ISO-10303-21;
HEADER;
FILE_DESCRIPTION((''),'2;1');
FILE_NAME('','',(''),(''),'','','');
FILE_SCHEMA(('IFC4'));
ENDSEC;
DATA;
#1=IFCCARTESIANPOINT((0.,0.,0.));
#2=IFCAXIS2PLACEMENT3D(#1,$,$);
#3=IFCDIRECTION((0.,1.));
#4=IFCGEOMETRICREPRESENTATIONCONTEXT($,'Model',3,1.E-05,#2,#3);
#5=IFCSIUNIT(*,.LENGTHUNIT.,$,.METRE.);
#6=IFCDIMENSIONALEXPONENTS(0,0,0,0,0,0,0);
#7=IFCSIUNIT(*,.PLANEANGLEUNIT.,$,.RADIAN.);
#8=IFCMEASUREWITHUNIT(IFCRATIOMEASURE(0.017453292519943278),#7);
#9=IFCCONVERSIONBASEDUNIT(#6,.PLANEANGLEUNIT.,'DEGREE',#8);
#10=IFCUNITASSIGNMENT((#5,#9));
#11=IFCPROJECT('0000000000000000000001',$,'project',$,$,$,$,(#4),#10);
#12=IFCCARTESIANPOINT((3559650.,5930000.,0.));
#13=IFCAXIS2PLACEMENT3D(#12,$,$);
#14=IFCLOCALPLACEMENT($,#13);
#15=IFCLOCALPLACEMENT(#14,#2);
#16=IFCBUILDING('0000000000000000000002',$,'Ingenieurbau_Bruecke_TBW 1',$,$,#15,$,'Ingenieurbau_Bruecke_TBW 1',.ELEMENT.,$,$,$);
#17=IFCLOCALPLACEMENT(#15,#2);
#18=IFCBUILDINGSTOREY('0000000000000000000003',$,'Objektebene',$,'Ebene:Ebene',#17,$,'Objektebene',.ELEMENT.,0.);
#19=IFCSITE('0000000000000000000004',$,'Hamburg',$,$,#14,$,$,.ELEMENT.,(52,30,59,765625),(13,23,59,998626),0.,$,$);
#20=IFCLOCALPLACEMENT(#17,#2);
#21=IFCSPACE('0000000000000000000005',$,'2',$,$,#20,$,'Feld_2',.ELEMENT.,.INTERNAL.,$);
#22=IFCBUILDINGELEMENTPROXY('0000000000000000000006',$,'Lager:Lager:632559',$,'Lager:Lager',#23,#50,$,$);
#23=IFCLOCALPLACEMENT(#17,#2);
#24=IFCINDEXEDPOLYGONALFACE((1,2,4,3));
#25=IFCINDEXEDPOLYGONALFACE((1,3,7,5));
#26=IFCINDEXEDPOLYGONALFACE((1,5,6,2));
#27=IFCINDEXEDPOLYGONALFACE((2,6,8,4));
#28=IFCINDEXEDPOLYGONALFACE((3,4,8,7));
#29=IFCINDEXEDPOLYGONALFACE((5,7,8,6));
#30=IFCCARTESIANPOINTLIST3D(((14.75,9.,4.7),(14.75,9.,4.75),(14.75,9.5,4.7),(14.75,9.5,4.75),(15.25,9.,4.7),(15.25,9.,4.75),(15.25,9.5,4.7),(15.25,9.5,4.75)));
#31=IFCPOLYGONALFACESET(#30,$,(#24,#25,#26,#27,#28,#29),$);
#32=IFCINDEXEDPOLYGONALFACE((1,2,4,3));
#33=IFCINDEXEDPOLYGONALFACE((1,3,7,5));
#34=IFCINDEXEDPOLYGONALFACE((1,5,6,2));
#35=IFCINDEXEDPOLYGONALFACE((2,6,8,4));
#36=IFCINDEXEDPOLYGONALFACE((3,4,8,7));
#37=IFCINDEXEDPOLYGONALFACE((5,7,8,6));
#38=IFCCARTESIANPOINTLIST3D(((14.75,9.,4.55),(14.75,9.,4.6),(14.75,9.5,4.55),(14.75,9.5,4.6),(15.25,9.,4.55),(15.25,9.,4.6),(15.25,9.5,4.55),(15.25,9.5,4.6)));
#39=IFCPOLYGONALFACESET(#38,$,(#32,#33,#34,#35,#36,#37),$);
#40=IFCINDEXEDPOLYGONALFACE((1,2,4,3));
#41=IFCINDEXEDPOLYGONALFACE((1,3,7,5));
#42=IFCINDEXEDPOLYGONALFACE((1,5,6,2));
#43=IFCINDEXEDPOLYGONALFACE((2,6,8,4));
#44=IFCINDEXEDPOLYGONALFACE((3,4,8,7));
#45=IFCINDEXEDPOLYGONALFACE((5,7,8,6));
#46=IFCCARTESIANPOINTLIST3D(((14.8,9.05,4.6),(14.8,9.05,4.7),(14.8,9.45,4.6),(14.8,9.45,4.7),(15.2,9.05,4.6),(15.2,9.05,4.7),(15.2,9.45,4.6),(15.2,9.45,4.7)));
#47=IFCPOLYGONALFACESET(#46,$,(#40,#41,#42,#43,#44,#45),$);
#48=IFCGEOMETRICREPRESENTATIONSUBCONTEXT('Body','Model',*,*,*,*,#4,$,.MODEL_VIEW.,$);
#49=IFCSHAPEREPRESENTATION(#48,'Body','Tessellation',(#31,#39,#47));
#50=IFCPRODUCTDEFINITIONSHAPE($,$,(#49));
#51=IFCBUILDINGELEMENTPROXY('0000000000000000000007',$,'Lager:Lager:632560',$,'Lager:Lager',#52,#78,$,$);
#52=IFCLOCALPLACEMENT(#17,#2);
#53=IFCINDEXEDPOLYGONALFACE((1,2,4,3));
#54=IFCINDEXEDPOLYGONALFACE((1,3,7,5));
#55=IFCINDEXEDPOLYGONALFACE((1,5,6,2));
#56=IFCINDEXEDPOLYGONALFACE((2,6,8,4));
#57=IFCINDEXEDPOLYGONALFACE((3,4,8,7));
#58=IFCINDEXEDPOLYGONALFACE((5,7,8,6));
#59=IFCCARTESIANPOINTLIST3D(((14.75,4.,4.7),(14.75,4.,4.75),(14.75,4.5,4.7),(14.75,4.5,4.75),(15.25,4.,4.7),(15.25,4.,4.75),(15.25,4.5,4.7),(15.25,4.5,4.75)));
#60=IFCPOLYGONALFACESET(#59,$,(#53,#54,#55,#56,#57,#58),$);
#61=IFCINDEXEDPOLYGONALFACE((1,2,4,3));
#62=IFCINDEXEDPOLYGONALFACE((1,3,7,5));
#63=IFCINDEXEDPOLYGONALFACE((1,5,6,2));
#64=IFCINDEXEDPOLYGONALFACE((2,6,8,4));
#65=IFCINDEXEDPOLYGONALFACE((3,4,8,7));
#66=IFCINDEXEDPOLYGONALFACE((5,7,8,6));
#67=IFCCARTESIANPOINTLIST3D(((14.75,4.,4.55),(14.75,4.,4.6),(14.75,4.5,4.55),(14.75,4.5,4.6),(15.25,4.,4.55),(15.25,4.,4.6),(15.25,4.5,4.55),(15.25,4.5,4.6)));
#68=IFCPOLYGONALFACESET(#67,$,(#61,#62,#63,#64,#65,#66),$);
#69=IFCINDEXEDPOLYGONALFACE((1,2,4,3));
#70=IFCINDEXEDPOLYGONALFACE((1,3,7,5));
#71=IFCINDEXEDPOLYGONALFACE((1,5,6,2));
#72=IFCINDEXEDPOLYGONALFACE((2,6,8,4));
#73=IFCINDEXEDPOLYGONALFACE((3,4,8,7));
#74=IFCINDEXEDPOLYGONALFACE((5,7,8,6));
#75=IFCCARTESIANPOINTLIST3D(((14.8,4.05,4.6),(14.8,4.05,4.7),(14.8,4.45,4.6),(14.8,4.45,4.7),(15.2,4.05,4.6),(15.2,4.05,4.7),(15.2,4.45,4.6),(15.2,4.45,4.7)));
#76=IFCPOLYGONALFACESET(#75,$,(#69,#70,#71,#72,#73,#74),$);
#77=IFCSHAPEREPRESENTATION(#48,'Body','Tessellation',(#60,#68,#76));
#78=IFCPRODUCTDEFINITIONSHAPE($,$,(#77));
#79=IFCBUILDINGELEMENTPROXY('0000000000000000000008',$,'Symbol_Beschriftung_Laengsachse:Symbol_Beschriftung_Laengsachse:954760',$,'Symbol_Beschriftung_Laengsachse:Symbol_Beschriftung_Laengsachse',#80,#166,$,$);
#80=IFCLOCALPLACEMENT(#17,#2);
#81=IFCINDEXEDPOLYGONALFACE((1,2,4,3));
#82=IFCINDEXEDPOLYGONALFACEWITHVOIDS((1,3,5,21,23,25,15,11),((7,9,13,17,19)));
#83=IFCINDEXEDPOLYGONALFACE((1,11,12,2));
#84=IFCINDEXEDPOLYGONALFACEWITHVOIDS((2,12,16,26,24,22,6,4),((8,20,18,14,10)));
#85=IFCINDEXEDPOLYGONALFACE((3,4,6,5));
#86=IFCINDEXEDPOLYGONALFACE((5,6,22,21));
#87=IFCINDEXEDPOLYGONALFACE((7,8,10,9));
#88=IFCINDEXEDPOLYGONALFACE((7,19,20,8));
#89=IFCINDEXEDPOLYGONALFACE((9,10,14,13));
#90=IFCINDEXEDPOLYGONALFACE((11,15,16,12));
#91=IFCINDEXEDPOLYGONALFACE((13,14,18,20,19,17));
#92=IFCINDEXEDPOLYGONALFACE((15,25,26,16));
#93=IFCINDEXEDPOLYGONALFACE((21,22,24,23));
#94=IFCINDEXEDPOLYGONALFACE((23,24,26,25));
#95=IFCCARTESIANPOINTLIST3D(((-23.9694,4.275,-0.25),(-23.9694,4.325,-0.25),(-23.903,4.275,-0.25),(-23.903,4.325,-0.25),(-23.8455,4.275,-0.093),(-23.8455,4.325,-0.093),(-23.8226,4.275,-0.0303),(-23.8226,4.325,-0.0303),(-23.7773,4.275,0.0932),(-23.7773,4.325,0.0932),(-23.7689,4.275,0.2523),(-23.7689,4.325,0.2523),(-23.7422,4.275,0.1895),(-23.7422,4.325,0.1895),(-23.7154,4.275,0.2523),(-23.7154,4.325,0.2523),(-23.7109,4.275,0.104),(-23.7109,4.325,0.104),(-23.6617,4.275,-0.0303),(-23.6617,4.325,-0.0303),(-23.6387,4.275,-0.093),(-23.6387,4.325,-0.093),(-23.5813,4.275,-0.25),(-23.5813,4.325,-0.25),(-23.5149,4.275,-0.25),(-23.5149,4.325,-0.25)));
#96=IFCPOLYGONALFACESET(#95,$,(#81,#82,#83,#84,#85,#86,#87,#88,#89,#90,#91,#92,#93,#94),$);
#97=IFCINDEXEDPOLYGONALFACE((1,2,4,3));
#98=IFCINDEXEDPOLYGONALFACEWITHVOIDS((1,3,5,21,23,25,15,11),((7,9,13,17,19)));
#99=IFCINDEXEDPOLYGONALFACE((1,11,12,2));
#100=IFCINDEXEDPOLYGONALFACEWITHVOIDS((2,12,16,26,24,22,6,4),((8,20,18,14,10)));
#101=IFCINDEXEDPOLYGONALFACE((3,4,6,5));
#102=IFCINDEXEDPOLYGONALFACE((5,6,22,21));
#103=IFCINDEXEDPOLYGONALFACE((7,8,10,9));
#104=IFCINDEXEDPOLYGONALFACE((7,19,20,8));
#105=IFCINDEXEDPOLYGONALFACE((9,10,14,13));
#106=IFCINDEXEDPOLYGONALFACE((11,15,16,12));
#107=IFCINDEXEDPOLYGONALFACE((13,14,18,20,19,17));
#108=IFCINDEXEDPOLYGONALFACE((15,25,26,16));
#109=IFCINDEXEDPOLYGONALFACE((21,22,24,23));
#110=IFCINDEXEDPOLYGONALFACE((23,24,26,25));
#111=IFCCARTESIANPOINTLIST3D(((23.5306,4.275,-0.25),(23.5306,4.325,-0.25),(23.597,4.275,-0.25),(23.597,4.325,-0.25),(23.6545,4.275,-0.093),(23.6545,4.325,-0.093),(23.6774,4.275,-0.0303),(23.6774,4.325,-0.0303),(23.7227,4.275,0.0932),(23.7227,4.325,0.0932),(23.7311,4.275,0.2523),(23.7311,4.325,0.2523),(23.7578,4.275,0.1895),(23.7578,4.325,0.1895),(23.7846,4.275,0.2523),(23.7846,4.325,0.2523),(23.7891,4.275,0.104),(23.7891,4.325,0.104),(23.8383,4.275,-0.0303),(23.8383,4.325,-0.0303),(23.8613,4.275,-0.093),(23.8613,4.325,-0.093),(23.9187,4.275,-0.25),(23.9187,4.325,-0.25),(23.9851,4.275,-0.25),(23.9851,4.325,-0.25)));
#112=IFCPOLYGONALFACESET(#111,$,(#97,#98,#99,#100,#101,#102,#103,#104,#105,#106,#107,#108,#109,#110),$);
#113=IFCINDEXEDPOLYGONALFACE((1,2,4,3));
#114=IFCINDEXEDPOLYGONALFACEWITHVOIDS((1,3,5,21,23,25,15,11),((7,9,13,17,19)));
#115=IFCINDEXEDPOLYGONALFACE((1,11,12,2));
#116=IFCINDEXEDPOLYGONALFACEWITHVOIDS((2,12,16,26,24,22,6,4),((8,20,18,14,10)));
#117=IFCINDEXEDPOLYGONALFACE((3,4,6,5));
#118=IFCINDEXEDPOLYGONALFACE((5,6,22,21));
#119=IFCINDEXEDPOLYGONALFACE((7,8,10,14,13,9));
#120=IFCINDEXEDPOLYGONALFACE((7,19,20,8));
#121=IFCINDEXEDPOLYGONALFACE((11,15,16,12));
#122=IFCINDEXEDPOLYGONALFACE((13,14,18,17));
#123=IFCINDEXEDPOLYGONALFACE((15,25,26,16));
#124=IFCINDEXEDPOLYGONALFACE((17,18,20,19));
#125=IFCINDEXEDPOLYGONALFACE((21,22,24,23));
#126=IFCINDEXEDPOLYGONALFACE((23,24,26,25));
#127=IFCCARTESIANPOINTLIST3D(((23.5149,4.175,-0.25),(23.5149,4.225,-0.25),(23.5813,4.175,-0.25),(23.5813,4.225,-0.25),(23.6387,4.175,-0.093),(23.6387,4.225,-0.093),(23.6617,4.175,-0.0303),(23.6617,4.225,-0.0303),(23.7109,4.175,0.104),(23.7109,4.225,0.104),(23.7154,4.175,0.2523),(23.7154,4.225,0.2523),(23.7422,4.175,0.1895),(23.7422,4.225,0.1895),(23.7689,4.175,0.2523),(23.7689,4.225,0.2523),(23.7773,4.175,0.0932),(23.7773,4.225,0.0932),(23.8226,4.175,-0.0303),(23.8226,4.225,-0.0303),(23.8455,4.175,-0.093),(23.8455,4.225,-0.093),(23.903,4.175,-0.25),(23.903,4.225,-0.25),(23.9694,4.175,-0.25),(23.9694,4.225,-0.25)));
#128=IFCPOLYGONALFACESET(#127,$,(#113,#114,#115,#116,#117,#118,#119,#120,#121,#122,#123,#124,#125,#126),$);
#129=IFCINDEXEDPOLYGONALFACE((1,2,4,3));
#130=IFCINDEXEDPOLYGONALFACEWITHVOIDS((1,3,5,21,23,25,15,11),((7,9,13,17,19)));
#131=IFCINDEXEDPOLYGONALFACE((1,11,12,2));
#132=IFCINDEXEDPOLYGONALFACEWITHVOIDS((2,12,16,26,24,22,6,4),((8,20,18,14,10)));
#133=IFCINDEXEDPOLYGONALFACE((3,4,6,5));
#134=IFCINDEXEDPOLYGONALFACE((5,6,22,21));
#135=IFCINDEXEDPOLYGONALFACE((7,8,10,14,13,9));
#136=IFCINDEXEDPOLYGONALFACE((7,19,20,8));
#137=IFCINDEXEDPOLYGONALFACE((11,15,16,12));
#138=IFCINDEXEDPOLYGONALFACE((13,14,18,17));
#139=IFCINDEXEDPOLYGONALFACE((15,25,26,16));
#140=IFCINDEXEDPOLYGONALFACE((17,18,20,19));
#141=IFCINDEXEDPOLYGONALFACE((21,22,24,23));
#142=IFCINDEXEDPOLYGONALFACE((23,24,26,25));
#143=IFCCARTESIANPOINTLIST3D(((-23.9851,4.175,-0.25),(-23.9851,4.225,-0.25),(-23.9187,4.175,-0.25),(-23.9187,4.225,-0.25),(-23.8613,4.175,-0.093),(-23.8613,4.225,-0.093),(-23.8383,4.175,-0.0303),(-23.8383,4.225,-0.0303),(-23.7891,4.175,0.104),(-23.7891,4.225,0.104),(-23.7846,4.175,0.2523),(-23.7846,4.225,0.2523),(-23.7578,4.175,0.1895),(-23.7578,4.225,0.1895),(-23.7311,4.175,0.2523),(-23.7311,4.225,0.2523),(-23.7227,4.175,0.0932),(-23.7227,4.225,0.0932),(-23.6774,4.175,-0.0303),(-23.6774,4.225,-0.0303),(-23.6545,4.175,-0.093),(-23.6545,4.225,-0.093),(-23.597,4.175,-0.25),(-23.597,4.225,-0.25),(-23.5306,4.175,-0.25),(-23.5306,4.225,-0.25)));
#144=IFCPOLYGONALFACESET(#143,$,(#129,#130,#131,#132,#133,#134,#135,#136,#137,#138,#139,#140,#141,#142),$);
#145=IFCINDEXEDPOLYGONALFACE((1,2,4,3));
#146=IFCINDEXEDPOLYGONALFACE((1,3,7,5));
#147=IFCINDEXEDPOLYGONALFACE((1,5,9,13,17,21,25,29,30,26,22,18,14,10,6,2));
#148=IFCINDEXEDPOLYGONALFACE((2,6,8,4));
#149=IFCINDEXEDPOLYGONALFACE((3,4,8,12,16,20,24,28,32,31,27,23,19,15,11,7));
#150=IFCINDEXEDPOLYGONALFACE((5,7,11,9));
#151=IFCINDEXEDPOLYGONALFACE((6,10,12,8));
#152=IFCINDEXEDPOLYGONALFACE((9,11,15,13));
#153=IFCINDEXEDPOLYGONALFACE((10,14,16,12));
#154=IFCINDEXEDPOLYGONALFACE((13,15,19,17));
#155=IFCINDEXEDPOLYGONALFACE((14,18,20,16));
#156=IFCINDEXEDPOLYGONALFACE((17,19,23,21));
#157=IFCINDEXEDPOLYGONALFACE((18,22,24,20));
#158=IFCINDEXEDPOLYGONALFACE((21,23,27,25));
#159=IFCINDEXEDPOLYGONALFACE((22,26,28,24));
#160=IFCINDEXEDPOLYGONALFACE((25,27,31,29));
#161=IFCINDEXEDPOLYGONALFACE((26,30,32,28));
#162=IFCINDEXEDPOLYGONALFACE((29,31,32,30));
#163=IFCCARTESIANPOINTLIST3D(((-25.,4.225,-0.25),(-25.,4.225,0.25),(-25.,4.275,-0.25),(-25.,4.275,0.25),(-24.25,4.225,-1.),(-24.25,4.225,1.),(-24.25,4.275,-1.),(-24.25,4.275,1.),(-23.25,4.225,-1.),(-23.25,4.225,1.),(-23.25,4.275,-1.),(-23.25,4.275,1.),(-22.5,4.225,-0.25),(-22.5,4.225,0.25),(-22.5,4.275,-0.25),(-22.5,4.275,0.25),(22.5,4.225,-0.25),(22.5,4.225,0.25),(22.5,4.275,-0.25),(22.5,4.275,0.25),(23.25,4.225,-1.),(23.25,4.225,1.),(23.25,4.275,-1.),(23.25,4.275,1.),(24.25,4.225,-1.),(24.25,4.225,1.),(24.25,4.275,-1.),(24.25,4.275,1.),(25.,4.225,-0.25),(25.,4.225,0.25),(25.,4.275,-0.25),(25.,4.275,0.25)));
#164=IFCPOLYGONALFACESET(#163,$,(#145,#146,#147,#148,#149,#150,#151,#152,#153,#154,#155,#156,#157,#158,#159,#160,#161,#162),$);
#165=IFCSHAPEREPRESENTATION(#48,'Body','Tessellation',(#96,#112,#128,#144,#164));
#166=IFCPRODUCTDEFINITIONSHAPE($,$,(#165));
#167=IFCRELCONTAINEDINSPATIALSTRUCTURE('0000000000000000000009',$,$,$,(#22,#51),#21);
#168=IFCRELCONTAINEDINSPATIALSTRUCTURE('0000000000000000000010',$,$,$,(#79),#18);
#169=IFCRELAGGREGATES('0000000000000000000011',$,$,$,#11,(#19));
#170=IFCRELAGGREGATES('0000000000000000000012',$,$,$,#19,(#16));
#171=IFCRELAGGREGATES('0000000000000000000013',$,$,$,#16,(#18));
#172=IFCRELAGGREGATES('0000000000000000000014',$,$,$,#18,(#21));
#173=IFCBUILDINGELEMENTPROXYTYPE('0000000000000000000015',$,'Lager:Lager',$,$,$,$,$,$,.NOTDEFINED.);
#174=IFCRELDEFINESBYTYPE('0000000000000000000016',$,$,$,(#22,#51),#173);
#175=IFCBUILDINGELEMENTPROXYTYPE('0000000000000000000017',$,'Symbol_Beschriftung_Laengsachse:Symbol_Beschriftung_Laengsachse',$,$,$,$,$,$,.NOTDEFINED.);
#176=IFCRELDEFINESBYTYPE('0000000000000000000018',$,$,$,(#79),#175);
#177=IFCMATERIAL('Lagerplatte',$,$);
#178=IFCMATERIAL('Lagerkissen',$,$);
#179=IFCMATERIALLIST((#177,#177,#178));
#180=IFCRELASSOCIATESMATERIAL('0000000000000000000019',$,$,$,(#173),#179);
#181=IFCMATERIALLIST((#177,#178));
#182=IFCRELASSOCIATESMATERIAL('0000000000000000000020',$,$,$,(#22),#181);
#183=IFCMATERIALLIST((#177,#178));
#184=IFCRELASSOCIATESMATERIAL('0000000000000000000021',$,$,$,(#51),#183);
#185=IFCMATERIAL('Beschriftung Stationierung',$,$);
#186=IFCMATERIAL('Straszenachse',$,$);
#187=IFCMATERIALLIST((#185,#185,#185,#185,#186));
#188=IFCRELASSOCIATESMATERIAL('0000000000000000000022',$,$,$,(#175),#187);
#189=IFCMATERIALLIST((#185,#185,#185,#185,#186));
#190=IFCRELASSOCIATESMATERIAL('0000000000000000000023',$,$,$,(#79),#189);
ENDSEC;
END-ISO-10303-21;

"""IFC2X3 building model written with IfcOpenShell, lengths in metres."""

from ifc_helpers import new_model, entity, si_unit, converted_unit, direction, frame, origin, origin_2d_with_axis, place, context, subcontext, project, spatial, polyline, rectangle, outline, extrude, source, transform, mapped, material, material_list, type_object, type_shapes, element, save


model = new_model("IFC2X3")

# Units and contexts
model_context = context("Model", 3, precision=1e-05, world=origin(), true_north=direction((0.0, 1.0)))
body_context = subcontext(model_context, "Body", "Model", "MODEL_VIEW")
ifc_project = project(units=[si_unit("LENGTHUNIT", "METRE"), converted_unit("PLANEANGLEUNIT", "DEGREE", entity("IfcRatioMeasure", 0.017453292519943278), si_unit("PLANEANGLEUNIT", "RADIAN"), dimensions=[0, 0, 0, 0, 0, 0, 0])], contexts=[model_context])

# Site, building, storey
site_placement = place(None, frame((3559650.0, 5930000.0, 0.0)))
site = spatial("IfcSite", under=ifc_project, at=site_placement, Name="Hamburg", CompositionType="ELEMENT", RefLatitude=(52, 30, 59, 765625), RefLongitude=(13, 23, 59, 998626), RefElevation=0.0)
building_placement = place(site_placement, origin())
building = spatial("IfcBuilding", under=site, at=building_placement, Name="Ingenieurbau_Bruecke_TBW 1", LongName="Ingenieurbau_Bruecke_TBW 1", CompositionType="ELEMENT")
storey_placement = place(building_placement, origin())
storey = spatial("IfcBuildingStorey", under=building, at=storey_placement, Name="Objektebene", ObjectType="Ebene:Ebene", LongName="Objektebene", CompositionType="ELEMENT", Elevation=0.0)

# Shared definitions
space_1_placement = place(storey_placement, origin())
space_1 = spatial("IfcSpace", under=storey, at=space_1_placement, Name="2", LongName="Feld_2", CompositionType="ELEMENT", InteriorOrExteriorSpace="INTERNAL")

# Building element proxies
ifc_material_1 = material(Name="Lagerplatte")
ifc_material_2 = material(Name="Lagerkissen")
ifc_material_list_1 = material_list([ifc_material_1, ifc_material_2])
ifc_material_list_2 = material_list([ifc_material_1, ifc_material_1, ifc_material_2])
building_element_proxy_type_1 = type_object("IfcBuildingElementProxyType", Name="Lager:Lager", PredefinedType="NOTDEFINED", material=ifc_material_list_2)
shared_shape_1 = source(origin(), body_context, "Body", "SweptSolid", [
    extrude(rectangle(XDim=0.5, YDim=0.5, at=origin_2d_with_axis()), frame((0.0, 0.0, 4.7), z_axis=(0.0, 0.0, 1.0), x_axis=(0.0, 1.0, 0.0)), (0.0, 0.0, 1.0), 0.05),
    extrude(rectangle(XDim=0.5, YDim=0.5, at=origin_2d_with_axis()), frame((0.0, 0.0, 4.55), z_axis=(0.0, 0.0, 1.0), x_axis=(0.0, 1.0, 0.0)), (0.0, 0.0, 1.0), 0.05),
    extrude(rectangle(XDim=0.4, YDim=0.4, at=origin_2d_with_axis()), frame((0.0, 0.0, 4.6), z_axis=(0.0, 0.0, 1.0), x_axis=(0.0, 1.0, 0.0)), (0.0, 0.0, 1.0), 0.1),
])
type_shapes(building_element_proxy_type_1, [shared_shape_1])
proxy_1_placement = place(space_1_placement, frame((15.0, 9.25, 0.0)))
element("IfcBuildingElementProxy", 1, at=proxy_1_placement, inside=space_1, type_object=building_element_proxy_type_1, material=ifc_material_list_1, Name="Lager:Lager:632559", ObjectType="Lager:Lager", context=body_context, shape_type="MappedRepresentation", body=[
    mapped(shared_shape_1, transform((0.0, 0.0, 0.0), scale=1.0)),
])
ifc_material_list_3 = material_list([ifc_material_1, ifc_material_2])
proxy_2_placement = place(space_1_placement, frame((15.0, 4.25, 0.0)))
element("IfcBuildingElementProxy", 2, at=proxy_2_placement, inside=space_1, type_object=building_element_proxy_type_1, material=ifc_material_list_3, Name="Lager:Lager:632560", ObjectType="Lager:Lager", context=body_context, shape_type="MappedRepresentation", body=[
    mapped(shared_shape_1, transform((0.0, 0.0, 0.0), scale=1.0)),
])
ifc_material_3 = material(Name="Beschriftung Stationierung")
ifc_material_4 = material(Name="Straszenachse")
ifc_material_list_4 = material_list([ifc_material_3, ifc_material_3, ifc_material_3, ifc_material_3, ifc_material_4])
ifc_material_list_5 = material_list([ifc_material_3, ifc_material_3, ifc_material_3, ifc_material_3, ifc_material_4])
building_element_proxy_type_2 = type_object("IfcBuildingElementProxyType", Name="Symbol_Beschriftung_Laengsachse:Symbol_Beschriftung_Laengsachse", PredefinedType="NOTDEFINED", material=ifc_material_list_5)
shared_shape_2 = source(origin(), body_context, "Body", "SweptSolid", [
    extrude(outline(polyline([(-0.2272, -0.1648), (-0.1609, -0.1648), (-0.1035, -0.0078), (0.1034, -0.0078), (0.1609, -0.1648), (0.2272, -0.1648), (0.0267, 0.3375), (-0.0267, 0.3375), (-0.2272, -0.1648)]), holes=[polyline([(-0.0804, 0.0549), (-0.0313, 0.1892), (0.0, 0.2747), (0.0352, 0.1784), (0.0805, 0.0549), (-0.0804, 0.0549)])]), frame((-23.7421, 0.025, -0.0852), z_axis=(0.0, 1.0, 0.0), x_axis=(-1.0, 0.0, 0.0)), (0.0, 0.0, 1.0), 0.05),
    extrude(outline(polyline([(-0.2272, -0.1648), (-0.1609, -0.1648), (-0.1035, -0.0078), (0.1034, -0.0078), (0.1609, -0.1648), (0.2272, -0.1648), (0.0267, 0.3375), (-0.0267, 0.3375), (-0.2272, -0.1648)]), holes=[polyline([(-0.0804, 0.0549), (-0.0313, 0.1892), (0.0, 0.2747), (0.0352, 0.1784), (0.0805, 0.0549), (-0.0804, 0.0549)])]), frame((23.7579, 0.025, -0.0852), z_axis=(0.0, 1.0, 0.0), x_axis=(-1.0, 0.0, 0.0)), (0.0, 0.0, 1.0), 0.05),
    extrude(outline(polyline([(-0.2373, -0.1499), (0.3035, -0.1499), (0.3233, -0.1003), (-0.0688, 0.2722), (-0.0934, 0.2105), (0.031, 0.0989), (-0.0457, -0.0932), (-0.2127, -0.0883), (-0.2373, -0.1499)]), holes=[polyline([(0.0212, -0.0951), (0.0809, 0.0544), (0.1788, -0.0334), (0.2551, -0.1018), (0.1641, -0.0992), (0.0212, -0.0951)])]), frame((23.7421, -0.075, -0.0852), z_axis=(0.0, 1.0, 0.0), x_axis=(0.370726, 0.0, 0.928742)), (0.0, 0.0, 1.0), 0.05),
    extrude(outline(polyline([(-0.2373, -0.1499), (0.3035, -0.1499), (0.3233, -0.1003), (-0.0688, 0.2722), (-0.0934, 0.2105), (0.031, 0.0989), (-0.0457, -0.0932), (-0.2127, -0.0883), (-0.2373, -0.1499)]), holes=[polyline([(0.0212, -0.0951), (0.0809, 0.0544), (0.1788, -0.0334), (0.2551, -0.1018), (0.1641, -0.0992), (0.0212, -0.0951)])]), frame((-23.7579, -0.075, -0.0852), z_axis=(0.0, 1.0, 0.0), x_axis=(0.370726, 0.0, 0.928742)), (0.0, 0.0, 1.0), 0.05),
    extrude(outline(polyline([(-17.5009, -17.8544), (-16.4402, -17.8544), (-15.7331, -17.1473), (-15.7331, -16.0867), (16.0867, 15.7331), (17.1473, 15.7331), (17.8544, 16.4402), (17.8544, 17.5009), (17.5009, 17.8544), (16.4402, 17.8544), (15.7331, 17.1473), (15.7331, 16.0867), (-16.0867, -15.7331), (-17.1473, -15.7331), (-17.8544, -16.4402), (-17.8544, -17.5009), (-17.5009, -17.8544)])), frame((0.0, -0.025, 0.0), z_axis=(0.0, 1.0, 0.0), x_axis=(0.707107, 0.0, 0.707107)), (0.0, 0.0, 1.0), 0.05),
])
type_shapes(building_element_proxy_type_2, [shared_shape_2])
proxy_3_placement = place(storey_placement, frame((0.0, 4.25, 0.0)))
element("IfcBuildingElementProxy", 3, at=proxy_3_placement, inside=storey, type_object=building_element_proxy_type_2, material=ifc_material_list_4, Name="Symbol_Beschriftung_Laengsachse:Symbol_Beschriftung_Laengsachse:954760", ObjectType="Symbol_Beschriftung_Laengsachse:Symbol_Beschriftung_Laengsachse", context=body_context, shape_type="MappedRepresentation", body=[
    mapped(shared_shape_2, transform((0.0, 0.0, 0.0), scale=1.0)),
])

save(model, "model.ifc")
